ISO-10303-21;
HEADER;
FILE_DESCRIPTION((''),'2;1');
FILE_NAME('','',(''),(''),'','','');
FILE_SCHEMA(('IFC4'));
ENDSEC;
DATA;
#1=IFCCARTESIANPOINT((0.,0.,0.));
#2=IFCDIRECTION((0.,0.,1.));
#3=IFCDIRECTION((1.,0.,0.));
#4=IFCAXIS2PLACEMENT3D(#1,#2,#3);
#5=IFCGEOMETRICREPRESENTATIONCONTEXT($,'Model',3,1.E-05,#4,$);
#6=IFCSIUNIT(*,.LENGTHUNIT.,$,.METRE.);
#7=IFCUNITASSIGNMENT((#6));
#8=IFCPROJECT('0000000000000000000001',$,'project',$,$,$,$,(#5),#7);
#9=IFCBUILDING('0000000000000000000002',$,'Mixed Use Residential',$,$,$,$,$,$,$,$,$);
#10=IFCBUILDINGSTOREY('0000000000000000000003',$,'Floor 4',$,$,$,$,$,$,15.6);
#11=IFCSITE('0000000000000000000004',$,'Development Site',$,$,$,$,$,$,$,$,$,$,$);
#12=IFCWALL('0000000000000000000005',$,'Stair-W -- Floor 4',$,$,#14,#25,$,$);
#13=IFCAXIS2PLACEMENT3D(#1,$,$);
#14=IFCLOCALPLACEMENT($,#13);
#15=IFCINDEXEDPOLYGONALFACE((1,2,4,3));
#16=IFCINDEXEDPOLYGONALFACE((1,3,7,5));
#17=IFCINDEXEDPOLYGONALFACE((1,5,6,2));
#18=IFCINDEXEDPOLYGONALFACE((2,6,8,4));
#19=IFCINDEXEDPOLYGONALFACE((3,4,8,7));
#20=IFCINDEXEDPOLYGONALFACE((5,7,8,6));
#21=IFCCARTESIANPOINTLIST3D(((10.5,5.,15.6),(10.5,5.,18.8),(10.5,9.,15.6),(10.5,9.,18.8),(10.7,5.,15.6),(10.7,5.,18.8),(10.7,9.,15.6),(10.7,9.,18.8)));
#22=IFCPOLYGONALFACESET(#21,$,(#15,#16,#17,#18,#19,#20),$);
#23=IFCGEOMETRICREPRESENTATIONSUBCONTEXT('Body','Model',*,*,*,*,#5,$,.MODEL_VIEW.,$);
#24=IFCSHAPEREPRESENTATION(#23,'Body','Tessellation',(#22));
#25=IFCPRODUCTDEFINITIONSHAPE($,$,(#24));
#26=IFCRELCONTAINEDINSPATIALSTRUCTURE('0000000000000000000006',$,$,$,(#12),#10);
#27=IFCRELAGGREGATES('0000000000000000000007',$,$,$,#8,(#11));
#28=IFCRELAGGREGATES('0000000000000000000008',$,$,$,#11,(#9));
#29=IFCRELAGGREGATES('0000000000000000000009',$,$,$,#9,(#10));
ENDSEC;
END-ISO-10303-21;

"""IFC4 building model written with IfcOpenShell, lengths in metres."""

from ifc_helpers import new_model, si_unit, frame, origin_with_axes, place, context, subcontext, project, spatial, indexed_curve, outline, extrude, element, save


model = new_model("IFC4")

# Units and contexts
model_context = context("Model", 3, precision=1e-05, world=origin_with_axes())
body_context = subcontext(model_context, "Body", "Model", "MODEL_VIEW")
ifc_project = project(units=[si_unit("LENGTHUNIT", "METRE")], contexts=[model_context])

# Site, building, storey
site = spatial("IfcSite", under=ifc_project, Name="Development Site")
building = spatial("IfcBuilding", under=site, Name="Mixed Use Residential")
storey = spatial("IfcBuildingStorey", under=building, Name="Floor 4", Elevation=15.6)

# Wall
for number, where, z_axis, x_axis, name in (
    (1, (10.7, 5.0, 15.6), (0.0, 0.0, 1.0), (0.0, 1.0, 0.0), "Stair-W -- Floor 4"),
):
    element("IfcWall", number, at=place(None, frame(where, z_axis=z_axis, x_axis=x_axis)), inside=storey, Name=name, context=body_context, shape_type="SweptSolid", body=[
        extrude(outline(indexed_curve([(0.0, 0.0), (0.0, 0.2), (4.0, 0.2), (4.0, 0.0), (0.0, 0.0)], self_intersect=False)), origin_with_axes(), (0.0, 0.0, 1.0), 3.2),
    ])

save(model, "model.ifc")
